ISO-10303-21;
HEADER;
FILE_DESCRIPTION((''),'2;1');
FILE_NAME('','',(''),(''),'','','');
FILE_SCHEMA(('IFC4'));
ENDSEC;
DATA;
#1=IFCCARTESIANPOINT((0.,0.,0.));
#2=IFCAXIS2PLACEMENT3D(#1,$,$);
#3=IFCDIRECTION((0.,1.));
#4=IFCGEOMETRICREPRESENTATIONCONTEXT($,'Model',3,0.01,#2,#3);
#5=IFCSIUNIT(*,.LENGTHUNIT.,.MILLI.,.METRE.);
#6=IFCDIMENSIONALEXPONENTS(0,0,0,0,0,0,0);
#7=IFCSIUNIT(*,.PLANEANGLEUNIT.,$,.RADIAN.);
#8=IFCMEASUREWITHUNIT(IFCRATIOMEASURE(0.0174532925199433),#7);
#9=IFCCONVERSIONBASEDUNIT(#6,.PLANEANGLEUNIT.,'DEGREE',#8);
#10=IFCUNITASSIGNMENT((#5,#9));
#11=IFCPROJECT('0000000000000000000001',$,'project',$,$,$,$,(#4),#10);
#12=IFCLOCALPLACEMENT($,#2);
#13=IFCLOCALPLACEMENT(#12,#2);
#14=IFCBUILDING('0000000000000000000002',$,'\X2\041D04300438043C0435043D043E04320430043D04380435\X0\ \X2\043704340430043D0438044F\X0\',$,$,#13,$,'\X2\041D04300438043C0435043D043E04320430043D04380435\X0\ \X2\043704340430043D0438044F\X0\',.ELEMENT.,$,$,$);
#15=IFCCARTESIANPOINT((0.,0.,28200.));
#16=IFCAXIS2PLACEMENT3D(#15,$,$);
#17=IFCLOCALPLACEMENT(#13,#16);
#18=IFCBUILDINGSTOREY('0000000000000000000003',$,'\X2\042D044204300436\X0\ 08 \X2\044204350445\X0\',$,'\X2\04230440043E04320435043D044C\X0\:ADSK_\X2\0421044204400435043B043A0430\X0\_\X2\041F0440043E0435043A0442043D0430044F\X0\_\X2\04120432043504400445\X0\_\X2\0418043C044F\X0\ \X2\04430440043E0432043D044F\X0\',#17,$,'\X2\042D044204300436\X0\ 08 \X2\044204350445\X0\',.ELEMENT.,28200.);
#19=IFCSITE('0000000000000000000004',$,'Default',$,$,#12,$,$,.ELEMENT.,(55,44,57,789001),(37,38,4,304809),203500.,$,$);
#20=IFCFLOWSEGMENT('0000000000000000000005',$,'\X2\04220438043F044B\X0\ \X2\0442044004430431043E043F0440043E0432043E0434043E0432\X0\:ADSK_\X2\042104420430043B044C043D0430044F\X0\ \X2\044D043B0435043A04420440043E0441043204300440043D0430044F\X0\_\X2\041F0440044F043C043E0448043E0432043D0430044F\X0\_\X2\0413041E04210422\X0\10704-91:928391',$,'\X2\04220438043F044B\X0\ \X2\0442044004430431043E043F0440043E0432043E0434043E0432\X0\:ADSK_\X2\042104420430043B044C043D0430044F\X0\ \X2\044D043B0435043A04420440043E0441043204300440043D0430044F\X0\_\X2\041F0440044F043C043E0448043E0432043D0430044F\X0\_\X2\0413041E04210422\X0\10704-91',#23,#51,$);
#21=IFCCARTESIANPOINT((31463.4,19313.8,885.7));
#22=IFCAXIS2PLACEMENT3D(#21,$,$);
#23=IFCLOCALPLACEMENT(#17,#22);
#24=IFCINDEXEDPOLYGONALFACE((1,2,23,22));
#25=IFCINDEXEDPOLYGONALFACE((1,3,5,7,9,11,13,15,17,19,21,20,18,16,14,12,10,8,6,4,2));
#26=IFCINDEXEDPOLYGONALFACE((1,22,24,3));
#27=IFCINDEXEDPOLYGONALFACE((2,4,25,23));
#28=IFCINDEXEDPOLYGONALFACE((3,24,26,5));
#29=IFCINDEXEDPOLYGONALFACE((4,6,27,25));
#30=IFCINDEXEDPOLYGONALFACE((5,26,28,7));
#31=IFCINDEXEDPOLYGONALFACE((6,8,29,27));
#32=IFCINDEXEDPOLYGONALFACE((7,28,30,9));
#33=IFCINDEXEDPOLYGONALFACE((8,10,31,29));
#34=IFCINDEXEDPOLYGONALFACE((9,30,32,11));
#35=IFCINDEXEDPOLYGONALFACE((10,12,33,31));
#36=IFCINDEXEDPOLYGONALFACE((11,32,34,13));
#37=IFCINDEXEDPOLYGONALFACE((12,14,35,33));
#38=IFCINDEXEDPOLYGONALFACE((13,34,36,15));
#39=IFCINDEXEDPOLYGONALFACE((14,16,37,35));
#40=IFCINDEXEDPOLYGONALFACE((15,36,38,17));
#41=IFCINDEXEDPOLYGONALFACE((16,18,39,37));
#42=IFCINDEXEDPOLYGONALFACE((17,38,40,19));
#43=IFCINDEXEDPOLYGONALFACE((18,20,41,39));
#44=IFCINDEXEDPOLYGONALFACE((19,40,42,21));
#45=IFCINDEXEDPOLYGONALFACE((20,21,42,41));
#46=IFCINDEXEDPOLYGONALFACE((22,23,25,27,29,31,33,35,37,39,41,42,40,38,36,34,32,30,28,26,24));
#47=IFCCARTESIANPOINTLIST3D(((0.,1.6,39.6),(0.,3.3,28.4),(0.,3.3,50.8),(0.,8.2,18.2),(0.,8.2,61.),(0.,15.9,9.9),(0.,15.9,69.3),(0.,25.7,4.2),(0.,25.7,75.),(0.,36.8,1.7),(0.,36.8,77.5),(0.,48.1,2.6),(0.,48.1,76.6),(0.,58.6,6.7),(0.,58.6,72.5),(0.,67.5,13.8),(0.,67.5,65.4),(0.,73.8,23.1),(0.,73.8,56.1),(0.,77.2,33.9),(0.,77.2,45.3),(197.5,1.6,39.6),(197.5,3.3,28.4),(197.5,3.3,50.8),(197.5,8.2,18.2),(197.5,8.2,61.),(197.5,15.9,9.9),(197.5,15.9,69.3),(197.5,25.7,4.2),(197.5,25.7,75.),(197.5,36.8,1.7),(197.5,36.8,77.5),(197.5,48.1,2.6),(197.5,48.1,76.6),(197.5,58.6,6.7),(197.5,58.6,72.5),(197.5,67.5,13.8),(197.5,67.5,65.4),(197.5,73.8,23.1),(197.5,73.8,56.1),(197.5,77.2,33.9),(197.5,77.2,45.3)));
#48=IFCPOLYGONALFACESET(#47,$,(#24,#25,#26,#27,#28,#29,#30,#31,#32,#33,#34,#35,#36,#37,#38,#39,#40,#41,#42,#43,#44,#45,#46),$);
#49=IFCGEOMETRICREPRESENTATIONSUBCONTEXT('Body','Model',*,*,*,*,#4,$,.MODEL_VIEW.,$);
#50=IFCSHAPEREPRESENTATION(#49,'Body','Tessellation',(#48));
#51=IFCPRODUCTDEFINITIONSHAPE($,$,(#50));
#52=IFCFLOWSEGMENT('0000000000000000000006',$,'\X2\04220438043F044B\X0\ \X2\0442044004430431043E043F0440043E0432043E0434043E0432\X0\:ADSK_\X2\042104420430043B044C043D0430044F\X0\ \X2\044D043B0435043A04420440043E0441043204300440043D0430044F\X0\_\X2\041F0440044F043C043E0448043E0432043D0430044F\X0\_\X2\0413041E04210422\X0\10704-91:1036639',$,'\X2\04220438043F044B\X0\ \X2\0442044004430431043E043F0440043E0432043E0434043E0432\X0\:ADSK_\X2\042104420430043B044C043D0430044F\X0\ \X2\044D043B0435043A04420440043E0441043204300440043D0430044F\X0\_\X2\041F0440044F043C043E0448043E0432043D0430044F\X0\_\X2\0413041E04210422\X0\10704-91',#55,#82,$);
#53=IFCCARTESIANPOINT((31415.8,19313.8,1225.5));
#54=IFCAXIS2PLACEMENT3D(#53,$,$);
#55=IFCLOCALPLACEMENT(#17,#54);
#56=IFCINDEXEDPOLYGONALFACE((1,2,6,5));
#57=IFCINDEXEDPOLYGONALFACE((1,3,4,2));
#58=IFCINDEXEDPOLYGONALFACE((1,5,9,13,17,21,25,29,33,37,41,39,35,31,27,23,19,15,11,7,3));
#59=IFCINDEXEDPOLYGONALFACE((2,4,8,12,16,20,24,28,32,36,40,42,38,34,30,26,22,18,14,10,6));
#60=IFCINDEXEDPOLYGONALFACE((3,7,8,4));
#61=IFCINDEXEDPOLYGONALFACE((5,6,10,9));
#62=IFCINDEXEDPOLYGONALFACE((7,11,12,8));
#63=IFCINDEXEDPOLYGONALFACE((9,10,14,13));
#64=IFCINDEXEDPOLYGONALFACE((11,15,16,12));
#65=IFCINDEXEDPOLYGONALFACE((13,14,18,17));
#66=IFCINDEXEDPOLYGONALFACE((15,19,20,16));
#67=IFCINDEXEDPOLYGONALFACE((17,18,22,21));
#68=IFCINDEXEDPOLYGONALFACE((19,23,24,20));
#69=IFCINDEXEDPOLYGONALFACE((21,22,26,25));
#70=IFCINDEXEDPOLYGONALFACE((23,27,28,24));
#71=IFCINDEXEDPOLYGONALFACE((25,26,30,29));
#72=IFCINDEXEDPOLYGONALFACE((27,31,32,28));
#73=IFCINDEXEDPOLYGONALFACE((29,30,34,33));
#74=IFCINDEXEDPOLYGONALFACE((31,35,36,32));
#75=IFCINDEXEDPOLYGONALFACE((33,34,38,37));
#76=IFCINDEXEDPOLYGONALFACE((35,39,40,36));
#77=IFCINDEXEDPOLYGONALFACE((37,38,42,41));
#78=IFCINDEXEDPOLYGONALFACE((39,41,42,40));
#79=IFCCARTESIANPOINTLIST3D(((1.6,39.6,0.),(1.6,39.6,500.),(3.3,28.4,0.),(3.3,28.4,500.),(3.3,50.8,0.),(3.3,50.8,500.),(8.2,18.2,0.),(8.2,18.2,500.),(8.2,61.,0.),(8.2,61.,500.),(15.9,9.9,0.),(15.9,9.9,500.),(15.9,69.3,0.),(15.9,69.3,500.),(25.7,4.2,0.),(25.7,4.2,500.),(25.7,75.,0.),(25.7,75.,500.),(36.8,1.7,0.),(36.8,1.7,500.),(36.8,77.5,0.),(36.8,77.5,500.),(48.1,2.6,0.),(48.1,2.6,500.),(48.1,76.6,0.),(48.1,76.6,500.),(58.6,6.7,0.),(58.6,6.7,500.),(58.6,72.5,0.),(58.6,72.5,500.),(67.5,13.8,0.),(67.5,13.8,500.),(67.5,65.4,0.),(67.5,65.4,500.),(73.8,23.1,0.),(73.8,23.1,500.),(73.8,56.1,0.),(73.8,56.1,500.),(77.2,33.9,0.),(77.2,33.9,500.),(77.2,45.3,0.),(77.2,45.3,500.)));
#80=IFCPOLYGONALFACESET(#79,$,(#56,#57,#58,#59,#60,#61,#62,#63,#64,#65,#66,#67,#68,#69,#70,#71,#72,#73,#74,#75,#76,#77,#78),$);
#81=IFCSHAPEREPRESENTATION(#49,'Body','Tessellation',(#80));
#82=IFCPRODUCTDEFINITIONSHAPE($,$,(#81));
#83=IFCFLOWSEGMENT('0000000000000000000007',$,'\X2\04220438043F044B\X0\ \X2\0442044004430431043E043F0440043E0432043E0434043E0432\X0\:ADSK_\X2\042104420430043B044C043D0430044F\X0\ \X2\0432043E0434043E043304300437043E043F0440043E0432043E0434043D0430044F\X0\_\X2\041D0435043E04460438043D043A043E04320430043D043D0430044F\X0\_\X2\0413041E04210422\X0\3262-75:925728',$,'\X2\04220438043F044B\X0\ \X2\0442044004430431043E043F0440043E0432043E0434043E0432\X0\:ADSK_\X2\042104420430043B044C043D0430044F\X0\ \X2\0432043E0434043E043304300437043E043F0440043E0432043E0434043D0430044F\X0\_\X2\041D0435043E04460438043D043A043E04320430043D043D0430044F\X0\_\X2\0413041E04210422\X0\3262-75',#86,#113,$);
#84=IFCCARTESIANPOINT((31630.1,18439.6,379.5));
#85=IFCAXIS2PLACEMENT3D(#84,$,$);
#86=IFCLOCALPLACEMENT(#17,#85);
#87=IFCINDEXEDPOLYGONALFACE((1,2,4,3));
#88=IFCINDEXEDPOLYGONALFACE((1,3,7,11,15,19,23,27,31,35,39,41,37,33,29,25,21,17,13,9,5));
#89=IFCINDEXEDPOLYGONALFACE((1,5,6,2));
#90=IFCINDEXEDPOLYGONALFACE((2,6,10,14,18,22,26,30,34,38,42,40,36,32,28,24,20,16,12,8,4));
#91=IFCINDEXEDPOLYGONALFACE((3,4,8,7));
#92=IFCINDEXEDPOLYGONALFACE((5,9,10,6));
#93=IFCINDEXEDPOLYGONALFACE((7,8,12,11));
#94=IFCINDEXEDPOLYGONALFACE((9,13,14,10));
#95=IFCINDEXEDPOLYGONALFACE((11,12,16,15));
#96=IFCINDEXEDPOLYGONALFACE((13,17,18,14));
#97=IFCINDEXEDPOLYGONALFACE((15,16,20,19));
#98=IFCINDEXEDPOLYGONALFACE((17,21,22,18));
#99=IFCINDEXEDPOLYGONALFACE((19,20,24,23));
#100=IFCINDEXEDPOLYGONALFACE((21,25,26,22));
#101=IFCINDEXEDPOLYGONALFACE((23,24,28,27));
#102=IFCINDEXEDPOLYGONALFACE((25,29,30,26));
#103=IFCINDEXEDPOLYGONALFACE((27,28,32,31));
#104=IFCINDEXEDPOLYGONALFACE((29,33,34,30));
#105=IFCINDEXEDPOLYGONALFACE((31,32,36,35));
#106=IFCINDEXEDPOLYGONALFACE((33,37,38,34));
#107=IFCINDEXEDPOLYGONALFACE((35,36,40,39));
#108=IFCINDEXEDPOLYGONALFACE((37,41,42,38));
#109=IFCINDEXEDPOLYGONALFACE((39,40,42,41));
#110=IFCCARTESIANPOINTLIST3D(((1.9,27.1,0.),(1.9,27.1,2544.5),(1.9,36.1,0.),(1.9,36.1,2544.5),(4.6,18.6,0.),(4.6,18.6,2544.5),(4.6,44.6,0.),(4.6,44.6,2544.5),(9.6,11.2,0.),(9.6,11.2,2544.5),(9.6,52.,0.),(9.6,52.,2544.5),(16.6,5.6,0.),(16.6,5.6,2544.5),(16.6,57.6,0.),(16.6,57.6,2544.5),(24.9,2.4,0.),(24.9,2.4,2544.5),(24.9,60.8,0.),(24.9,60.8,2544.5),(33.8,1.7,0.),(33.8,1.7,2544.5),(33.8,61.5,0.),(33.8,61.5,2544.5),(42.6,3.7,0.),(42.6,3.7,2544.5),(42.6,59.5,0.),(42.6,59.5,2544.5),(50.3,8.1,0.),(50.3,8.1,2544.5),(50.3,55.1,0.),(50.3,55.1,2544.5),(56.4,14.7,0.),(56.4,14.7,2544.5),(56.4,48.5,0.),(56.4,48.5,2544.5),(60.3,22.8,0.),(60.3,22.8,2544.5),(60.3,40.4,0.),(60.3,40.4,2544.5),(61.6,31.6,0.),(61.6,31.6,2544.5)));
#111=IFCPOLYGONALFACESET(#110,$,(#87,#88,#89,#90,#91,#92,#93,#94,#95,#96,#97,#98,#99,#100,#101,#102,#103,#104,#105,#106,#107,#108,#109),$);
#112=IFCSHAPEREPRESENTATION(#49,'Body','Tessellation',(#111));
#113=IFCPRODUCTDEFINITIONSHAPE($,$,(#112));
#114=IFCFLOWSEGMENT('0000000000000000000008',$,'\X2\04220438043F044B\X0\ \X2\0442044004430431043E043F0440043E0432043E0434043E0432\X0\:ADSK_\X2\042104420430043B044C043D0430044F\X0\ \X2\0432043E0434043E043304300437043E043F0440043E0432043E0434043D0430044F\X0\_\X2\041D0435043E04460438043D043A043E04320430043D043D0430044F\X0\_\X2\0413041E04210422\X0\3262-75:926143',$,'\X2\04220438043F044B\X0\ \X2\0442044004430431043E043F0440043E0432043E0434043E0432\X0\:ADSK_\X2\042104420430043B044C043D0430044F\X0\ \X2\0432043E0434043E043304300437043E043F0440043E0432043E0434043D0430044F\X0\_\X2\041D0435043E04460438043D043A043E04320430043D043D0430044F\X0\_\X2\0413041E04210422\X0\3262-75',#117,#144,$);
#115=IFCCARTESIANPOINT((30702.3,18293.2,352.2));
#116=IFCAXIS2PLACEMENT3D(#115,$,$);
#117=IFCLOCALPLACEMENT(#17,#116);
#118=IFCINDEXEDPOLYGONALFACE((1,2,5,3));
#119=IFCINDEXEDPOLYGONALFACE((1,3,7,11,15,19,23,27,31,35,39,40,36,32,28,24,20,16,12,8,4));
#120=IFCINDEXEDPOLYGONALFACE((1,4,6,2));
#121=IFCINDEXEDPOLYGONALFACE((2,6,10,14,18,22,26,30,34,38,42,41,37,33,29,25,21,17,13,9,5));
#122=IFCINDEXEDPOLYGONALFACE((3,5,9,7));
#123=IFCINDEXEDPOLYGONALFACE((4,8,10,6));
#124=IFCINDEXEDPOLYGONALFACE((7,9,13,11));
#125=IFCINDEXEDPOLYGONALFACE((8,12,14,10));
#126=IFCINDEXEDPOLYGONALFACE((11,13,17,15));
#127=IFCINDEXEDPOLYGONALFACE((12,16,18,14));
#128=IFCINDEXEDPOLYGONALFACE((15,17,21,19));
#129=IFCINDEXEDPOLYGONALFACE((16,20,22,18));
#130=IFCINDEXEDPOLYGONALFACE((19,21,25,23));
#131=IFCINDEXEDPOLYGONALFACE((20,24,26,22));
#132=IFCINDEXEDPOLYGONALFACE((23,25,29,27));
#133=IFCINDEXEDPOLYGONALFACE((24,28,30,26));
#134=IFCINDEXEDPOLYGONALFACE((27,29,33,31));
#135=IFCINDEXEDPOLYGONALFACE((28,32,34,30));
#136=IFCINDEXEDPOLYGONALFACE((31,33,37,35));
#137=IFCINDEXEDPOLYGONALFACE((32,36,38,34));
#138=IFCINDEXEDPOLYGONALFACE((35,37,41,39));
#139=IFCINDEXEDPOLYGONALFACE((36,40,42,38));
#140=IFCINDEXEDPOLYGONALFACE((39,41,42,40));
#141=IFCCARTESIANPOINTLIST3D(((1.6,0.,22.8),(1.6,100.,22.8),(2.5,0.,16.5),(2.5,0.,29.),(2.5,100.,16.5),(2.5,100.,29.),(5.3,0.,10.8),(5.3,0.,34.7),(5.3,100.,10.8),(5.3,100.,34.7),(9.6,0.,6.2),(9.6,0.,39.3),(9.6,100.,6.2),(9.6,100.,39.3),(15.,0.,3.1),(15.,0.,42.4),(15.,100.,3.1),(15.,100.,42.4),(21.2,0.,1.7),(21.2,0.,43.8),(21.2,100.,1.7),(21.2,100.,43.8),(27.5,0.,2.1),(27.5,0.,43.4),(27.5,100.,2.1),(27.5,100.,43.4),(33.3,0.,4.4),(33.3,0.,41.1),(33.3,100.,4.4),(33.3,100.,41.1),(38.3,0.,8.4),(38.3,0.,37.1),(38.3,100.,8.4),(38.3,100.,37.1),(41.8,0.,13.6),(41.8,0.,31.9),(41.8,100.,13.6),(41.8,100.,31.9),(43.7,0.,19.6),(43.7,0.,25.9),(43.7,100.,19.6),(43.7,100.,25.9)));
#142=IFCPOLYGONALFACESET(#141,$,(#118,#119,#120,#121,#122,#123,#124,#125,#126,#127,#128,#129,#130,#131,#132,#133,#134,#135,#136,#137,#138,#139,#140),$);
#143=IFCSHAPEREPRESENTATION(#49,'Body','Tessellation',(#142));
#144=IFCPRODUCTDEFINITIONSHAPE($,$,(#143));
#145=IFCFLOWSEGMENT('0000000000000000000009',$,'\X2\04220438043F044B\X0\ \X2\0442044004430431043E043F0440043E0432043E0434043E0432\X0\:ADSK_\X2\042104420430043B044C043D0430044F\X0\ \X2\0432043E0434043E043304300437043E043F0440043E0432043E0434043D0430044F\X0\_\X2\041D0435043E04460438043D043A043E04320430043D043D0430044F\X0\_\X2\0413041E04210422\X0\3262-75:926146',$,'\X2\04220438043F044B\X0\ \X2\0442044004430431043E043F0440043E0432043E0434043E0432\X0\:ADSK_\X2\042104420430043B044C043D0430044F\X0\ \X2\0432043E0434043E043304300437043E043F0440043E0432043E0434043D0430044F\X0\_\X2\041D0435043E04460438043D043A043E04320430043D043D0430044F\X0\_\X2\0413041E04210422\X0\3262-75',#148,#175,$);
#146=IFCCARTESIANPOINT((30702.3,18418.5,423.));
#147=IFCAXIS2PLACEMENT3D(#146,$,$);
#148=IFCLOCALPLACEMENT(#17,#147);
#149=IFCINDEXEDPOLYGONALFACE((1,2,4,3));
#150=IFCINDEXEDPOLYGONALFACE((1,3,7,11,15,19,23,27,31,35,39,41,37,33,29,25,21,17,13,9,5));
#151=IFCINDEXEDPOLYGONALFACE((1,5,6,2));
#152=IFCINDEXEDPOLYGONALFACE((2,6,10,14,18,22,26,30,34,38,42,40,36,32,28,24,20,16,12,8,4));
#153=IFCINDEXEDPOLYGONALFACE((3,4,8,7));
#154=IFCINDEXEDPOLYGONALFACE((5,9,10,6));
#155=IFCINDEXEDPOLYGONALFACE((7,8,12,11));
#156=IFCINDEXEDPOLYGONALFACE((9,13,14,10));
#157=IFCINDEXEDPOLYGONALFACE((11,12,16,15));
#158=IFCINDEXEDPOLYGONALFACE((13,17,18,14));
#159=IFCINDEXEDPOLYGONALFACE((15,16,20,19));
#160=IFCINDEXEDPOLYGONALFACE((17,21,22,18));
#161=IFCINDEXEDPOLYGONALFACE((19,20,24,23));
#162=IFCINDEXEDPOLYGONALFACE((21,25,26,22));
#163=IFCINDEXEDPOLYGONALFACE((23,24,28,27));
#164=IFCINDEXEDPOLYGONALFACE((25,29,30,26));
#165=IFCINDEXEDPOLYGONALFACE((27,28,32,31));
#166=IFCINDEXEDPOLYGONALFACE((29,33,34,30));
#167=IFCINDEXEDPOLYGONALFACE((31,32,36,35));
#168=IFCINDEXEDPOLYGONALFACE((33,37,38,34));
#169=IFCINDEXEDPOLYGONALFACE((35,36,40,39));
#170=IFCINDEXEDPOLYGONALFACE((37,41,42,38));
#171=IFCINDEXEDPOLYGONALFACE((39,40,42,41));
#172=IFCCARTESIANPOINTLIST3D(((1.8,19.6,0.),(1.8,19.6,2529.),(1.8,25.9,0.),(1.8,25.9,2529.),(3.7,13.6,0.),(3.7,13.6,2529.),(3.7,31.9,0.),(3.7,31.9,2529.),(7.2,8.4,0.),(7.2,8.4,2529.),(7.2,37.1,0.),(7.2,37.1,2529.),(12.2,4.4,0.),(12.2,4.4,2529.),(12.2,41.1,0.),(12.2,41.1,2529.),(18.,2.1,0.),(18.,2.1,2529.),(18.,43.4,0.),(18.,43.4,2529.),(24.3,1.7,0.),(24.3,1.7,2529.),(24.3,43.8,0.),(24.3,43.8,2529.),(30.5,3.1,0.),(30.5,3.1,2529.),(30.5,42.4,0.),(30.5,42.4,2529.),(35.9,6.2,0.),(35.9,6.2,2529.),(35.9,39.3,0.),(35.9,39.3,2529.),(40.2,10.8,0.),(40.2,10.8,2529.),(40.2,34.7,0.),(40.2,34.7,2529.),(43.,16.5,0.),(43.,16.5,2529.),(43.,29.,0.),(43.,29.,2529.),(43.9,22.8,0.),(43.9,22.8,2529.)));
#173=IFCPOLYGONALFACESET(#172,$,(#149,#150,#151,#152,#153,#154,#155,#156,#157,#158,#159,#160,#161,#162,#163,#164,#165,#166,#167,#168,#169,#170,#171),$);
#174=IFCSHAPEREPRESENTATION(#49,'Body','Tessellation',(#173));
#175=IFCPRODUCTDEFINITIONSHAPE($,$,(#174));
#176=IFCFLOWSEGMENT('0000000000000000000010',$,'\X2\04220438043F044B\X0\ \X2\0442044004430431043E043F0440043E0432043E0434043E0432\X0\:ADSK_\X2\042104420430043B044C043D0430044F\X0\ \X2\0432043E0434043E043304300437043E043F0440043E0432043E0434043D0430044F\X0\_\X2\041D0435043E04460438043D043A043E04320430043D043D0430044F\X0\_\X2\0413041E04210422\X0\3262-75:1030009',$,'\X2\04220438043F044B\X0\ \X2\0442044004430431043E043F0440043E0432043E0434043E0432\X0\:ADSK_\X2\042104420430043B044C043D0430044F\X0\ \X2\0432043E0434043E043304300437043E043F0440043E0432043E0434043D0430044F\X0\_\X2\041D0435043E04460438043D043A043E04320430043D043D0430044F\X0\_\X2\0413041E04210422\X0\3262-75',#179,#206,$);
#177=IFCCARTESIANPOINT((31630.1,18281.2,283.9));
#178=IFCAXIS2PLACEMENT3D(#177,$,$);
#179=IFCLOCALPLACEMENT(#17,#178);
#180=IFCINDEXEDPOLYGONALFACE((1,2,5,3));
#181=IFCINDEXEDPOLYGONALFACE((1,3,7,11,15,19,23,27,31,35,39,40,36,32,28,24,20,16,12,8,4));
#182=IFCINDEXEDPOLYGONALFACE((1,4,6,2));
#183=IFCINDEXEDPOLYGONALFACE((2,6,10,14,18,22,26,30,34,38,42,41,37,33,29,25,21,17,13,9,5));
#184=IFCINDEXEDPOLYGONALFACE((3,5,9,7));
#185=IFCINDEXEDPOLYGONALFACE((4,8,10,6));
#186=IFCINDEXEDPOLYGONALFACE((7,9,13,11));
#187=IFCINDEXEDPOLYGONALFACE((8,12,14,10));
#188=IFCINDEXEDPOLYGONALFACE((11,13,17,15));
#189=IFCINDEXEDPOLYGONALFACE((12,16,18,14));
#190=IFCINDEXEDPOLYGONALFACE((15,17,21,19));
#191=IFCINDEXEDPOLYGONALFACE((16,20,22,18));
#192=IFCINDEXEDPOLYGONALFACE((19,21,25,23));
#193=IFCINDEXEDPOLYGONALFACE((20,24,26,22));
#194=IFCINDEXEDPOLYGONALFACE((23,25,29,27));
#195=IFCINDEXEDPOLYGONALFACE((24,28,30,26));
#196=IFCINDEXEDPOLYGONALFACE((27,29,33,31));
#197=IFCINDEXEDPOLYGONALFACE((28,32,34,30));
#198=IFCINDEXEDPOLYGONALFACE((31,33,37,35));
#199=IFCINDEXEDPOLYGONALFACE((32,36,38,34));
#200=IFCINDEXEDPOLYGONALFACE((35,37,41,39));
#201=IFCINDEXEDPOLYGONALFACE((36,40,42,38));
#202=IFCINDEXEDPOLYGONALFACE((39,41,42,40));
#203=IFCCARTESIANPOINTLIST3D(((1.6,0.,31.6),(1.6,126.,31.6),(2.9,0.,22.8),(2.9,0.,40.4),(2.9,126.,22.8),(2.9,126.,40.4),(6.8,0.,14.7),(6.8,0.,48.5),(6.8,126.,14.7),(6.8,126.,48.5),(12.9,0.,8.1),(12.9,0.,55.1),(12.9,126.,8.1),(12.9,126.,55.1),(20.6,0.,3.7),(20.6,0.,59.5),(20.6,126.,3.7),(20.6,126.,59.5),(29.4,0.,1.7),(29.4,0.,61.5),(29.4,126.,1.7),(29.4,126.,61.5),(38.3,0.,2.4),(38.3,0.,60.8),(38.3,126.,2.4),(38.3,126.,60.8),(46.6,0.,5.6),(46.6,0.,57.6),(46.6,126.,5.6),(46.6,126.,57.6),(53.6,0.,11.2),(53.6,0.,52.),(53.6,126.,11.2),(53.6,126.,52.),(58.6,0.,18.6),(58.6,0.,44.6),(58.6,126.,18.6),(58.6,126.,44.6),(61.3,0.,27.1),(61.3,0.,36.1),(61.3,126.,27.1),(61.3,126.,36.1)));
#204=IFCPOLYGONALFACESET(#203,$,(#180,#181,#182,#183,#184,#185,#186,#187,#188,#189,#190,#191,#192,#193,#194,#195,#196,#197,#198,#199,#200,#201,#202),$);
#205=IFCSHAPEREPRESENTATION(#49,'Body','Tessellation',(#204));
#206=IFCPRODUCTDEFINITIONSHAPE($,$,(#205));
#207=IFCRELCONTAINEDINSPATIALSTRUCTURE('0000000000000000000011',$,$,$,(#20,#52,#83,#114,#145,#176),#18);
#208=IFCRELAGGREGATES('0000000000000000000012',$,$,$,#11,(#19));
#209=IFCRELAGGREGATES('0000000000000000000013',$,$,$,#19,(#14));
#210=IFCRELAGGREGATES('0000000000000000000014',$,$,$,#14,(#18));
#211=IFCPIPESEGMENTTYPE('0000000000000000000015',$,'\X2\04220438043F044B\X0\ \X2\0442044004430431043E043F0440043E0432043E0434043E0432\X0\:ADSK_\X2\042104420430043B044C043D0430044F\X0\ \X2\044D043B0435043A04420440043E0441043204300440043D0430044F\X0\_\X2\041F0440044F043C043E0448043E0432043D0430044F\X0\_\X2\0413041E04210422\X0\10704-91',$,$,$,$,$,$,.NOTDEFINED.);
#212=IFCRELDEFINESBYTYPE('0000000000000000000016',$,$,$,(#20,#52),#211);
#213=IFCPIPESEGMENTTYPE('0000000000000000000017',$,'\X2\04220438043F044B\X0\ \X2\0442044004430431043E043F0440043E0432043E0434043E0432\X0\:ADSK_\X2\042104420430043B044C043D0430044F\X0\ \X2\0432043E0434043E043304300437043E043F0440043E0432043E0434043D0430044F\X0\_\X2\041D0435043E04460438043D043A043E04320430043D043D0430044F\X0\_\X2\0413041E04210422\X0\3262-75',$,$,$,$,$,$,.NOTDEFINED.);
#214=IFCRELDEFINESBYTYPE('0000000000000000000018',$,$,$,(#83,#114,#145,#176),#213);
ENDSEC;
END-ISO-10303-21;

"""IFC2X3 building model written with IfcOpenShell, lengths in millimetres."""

from ifc_helpers import new_model, entity, si_unit, converted_unit, direction, frame, origin, origin_2d_with_axis, place, context, subcontext, project, spatial, circle, extrude, type_object, element, save


model = new_model("IFC2X3")

# Units and contexts
model_context = context("Model", 3, precision=0.01, world=origin(), true_north=direction((0.0, 1.0)))
body_context = subcontext(model_context, "Body", "Model", "MODEL_VIEW")
ifc_project = project(units=[si_unit("LENGTHUNIT", "METRE", prefix="MILLI"), converted_unit("PLANEANGLEUNIT", "DEGREE", entity("IfcRatioMeasure", 0.0174532925199433), si_unit("PLANEANGLEUNIT", "RADIAN"), dimensions=[0, 0, 0, 0, 0, 0, 0])], contexts=[model_context])

# Site, building, storey
site_placement = place(None, origin())
site = spatial("IfcSite", under=ifc_project, at=site_placement, Name="Default", CompositionType="ELEMENT", RefLatitude=(55, 44, 57, 789001), RefLongitude=(37, 38, 4, 304809), RefElevation=203500.0)
building_placement = place(site_placement, origin())
building = spatial("IfcBuilding", under=site, at=building_placement, Name="Наименование здания", LongName="Наименование здания", CompositionType="ELEMENT")
storey_placement = place(building_placement, frame((0.0, 0.0, 28200.0)))
storey = spatial("IfcBuildingStorey", under=building, at=storey_placement, Name="Этаж 08 тех", ObjectType="Уровень:ADSK_Стрелка_Проектная_Вверх_Имя уровня", LongName="Этаж 08 тех", CompositionType="ELEMENT", Elevation=28200.0)

# Flow segments
pipe_segment_type_1 = type_object("IfcPipeSegmentType", Name="Типы трубопроводов:ADSK_Стальная электросварная_Прямошовная_ГОСТ10704-91", PredefinedType="NOTDEFINED")
flow_segment_1_placement = place(storey_placement, frame((31463.4, 19313.8, 885.7)))
element("IfcFlowSegment", 1, at=flow_segment_1_placement, inside=storey, type_object=pipe_segment_type_1, Name="Типы трубопроводов:ADSK_Стальная электросварная_Прямошовная_ГОСТ10704-91:928391", ObjectType="Типы трубопроводов:ADSK_Стальная электросварная_Прямошовная_ГОСТ10704-91", context=body_context, shape_type="SweptSolid", body=[
    extrude(circle(Radius=38.0, at=origin_2d_with_axis()), frame((0.0, 39.6, 39.6), z_axis=(1.0, 0.0, 0.0), x_axis=(0.0, -1.0, 0.0)), (0.0, 0.0, 1.0), 197.5),
])
flow_segment_2_placement = place(storey_placement, frame((31415.8, 19313.8, 1225.5)))
element("IfcFlowSegment", 2, at=flow_segment_2_placement, inside=storey, type_object=pipe_segment_type_1, Name="Типы трубопроводов:ADSK_Стальная электросварная_Прямошовная_ГОСТ10704-91:1036639", ObjectType="Типы трубопроводов:ADSK_Стальная электросварная_Прямошовная_ГОСТ10704-91", context=body_context, shape_type="SweptSolid", body=[
    extrude(circle(Radius=38.0, at=origin_2d_with_axis()), frame((39.6, 39.6, 0.0), z_axis=(0.0, 0.0, 1.0), x_axis=(-1.0, 0.0, 0.0)), (0.0, 0.0, 1.0), 500.0),
])
pipe_segment_type_2 = type_object("IfcPipeSegmentType", Name="Типы трубопроводов:ADSK_Стальная водогазопроводная_Неоцинкованная_ГОСТ3262-75", PredefinedType="NOTDEFINED")
flow_segment_3_placement = place(storey_placement, frame((31630.1, 18439.6, 379.5)))
element("IfcFlowSegment", 3, at=flow_segment_3_placement, inside=storey, type_object=pipe_segment_type_2, Name="Типы трубопроводов:ADSK_Стальная водогазопроводная_Неоцинкованная_ГОСТ3262-75:925728", ObjectType="Типы трубопроводов:ADSK_Стальная водогазопроводная_Неоцинкованная_ГОСТ3262-75", context=body_context, shape_type="SweptSolid", body=[
    extrude(circle(Radius=30.0, at=origin_2d_with_axis()), frame((31.6, 31.6, 0.0)), (0.0, 0.0, 1.0), 2544.5),
])
flow_segment_4_placement = place(storey_placement, frame((30702.3, 18293.2, 352.2)))
element("IfcFlowSegment", 4, at=flow_segment_4_placement, inside=storey, type_object=pipe_segment_type_2, Name="Типы трубопроводов:ADSK_Стальная водогазопроводная_Неоцинкованная_ГОСТ3262-75:926143", ObjectType="Типы трубопроводов:ADSK_Стальная водогазопроводная_Неоцинкованная_ГОСТ3262-75", context=body_context, shape_type="SweptSolid", body=[
    extrude(circle(Radius=21.1, at=origin_2d_with_axis()), frame((22.8, 0.0, 22.8), z_axis=(0.0, 1.0, 0.0), x_axis=(-1.0, 0.0, 0.0)), (0.0, 0.0, 1.0), 100.0),
])
flow_segment_5_placement = place(storey_placement, frame((30702.3, 18418.5, 423.0)))
element("IfcFlowSegment", 5, at=flow_segment_5_placement, inside=storey, type_object=pipe_segment_type_2, Name="Типы трубопроводов:ADSK_Стальная водогазопроводная_Неоцинкованная_ГОСТ3262-75:926146", ObjectType="Типы трубопроводов:ADSK_Стальная водогазопроводная_Неоцинкованная_ГОСТ3262-75", context=body_context, shape_type="SweptSolid", body=[
    extrude(circle(Radius=21.1, at=origin_2d_with_axis()), frame((22.8, 22.8, 0.0)), (0.0, 0.0, 1.0), 2529.0),
])
flow_segment_6_placement = place(storey_placement, frame((31630.1, 18281.2, 283.9)))
element("IfcFlowSegment", 6, at=flow_segment_6_placement, inside=storey, type_object=pipe_segment_type_2, Name="Типы трубопроводов:ADSK_Стальная водогазопроводная_Неоцинкованная_ГОСТ3262-75:1030009", ObjectType="Типы трубопроводов:ADSK_Стальная водогазопроводная_Неоцинкованная_ГОСТ3262-75", context=body_context, shape_type="SweptSolid", body=[
    extrude(circle(Radius=30.0, at=origin_2d_with_axis()), frame((31.6, 0.0, 31.6), z_axis=(0.0, 1.0, 0.0), x_axis=(-1.0, 0.0, 0.0)), (0.0, 0.0, 1.0), 126.0),
])

save(model, "model.ifc")
